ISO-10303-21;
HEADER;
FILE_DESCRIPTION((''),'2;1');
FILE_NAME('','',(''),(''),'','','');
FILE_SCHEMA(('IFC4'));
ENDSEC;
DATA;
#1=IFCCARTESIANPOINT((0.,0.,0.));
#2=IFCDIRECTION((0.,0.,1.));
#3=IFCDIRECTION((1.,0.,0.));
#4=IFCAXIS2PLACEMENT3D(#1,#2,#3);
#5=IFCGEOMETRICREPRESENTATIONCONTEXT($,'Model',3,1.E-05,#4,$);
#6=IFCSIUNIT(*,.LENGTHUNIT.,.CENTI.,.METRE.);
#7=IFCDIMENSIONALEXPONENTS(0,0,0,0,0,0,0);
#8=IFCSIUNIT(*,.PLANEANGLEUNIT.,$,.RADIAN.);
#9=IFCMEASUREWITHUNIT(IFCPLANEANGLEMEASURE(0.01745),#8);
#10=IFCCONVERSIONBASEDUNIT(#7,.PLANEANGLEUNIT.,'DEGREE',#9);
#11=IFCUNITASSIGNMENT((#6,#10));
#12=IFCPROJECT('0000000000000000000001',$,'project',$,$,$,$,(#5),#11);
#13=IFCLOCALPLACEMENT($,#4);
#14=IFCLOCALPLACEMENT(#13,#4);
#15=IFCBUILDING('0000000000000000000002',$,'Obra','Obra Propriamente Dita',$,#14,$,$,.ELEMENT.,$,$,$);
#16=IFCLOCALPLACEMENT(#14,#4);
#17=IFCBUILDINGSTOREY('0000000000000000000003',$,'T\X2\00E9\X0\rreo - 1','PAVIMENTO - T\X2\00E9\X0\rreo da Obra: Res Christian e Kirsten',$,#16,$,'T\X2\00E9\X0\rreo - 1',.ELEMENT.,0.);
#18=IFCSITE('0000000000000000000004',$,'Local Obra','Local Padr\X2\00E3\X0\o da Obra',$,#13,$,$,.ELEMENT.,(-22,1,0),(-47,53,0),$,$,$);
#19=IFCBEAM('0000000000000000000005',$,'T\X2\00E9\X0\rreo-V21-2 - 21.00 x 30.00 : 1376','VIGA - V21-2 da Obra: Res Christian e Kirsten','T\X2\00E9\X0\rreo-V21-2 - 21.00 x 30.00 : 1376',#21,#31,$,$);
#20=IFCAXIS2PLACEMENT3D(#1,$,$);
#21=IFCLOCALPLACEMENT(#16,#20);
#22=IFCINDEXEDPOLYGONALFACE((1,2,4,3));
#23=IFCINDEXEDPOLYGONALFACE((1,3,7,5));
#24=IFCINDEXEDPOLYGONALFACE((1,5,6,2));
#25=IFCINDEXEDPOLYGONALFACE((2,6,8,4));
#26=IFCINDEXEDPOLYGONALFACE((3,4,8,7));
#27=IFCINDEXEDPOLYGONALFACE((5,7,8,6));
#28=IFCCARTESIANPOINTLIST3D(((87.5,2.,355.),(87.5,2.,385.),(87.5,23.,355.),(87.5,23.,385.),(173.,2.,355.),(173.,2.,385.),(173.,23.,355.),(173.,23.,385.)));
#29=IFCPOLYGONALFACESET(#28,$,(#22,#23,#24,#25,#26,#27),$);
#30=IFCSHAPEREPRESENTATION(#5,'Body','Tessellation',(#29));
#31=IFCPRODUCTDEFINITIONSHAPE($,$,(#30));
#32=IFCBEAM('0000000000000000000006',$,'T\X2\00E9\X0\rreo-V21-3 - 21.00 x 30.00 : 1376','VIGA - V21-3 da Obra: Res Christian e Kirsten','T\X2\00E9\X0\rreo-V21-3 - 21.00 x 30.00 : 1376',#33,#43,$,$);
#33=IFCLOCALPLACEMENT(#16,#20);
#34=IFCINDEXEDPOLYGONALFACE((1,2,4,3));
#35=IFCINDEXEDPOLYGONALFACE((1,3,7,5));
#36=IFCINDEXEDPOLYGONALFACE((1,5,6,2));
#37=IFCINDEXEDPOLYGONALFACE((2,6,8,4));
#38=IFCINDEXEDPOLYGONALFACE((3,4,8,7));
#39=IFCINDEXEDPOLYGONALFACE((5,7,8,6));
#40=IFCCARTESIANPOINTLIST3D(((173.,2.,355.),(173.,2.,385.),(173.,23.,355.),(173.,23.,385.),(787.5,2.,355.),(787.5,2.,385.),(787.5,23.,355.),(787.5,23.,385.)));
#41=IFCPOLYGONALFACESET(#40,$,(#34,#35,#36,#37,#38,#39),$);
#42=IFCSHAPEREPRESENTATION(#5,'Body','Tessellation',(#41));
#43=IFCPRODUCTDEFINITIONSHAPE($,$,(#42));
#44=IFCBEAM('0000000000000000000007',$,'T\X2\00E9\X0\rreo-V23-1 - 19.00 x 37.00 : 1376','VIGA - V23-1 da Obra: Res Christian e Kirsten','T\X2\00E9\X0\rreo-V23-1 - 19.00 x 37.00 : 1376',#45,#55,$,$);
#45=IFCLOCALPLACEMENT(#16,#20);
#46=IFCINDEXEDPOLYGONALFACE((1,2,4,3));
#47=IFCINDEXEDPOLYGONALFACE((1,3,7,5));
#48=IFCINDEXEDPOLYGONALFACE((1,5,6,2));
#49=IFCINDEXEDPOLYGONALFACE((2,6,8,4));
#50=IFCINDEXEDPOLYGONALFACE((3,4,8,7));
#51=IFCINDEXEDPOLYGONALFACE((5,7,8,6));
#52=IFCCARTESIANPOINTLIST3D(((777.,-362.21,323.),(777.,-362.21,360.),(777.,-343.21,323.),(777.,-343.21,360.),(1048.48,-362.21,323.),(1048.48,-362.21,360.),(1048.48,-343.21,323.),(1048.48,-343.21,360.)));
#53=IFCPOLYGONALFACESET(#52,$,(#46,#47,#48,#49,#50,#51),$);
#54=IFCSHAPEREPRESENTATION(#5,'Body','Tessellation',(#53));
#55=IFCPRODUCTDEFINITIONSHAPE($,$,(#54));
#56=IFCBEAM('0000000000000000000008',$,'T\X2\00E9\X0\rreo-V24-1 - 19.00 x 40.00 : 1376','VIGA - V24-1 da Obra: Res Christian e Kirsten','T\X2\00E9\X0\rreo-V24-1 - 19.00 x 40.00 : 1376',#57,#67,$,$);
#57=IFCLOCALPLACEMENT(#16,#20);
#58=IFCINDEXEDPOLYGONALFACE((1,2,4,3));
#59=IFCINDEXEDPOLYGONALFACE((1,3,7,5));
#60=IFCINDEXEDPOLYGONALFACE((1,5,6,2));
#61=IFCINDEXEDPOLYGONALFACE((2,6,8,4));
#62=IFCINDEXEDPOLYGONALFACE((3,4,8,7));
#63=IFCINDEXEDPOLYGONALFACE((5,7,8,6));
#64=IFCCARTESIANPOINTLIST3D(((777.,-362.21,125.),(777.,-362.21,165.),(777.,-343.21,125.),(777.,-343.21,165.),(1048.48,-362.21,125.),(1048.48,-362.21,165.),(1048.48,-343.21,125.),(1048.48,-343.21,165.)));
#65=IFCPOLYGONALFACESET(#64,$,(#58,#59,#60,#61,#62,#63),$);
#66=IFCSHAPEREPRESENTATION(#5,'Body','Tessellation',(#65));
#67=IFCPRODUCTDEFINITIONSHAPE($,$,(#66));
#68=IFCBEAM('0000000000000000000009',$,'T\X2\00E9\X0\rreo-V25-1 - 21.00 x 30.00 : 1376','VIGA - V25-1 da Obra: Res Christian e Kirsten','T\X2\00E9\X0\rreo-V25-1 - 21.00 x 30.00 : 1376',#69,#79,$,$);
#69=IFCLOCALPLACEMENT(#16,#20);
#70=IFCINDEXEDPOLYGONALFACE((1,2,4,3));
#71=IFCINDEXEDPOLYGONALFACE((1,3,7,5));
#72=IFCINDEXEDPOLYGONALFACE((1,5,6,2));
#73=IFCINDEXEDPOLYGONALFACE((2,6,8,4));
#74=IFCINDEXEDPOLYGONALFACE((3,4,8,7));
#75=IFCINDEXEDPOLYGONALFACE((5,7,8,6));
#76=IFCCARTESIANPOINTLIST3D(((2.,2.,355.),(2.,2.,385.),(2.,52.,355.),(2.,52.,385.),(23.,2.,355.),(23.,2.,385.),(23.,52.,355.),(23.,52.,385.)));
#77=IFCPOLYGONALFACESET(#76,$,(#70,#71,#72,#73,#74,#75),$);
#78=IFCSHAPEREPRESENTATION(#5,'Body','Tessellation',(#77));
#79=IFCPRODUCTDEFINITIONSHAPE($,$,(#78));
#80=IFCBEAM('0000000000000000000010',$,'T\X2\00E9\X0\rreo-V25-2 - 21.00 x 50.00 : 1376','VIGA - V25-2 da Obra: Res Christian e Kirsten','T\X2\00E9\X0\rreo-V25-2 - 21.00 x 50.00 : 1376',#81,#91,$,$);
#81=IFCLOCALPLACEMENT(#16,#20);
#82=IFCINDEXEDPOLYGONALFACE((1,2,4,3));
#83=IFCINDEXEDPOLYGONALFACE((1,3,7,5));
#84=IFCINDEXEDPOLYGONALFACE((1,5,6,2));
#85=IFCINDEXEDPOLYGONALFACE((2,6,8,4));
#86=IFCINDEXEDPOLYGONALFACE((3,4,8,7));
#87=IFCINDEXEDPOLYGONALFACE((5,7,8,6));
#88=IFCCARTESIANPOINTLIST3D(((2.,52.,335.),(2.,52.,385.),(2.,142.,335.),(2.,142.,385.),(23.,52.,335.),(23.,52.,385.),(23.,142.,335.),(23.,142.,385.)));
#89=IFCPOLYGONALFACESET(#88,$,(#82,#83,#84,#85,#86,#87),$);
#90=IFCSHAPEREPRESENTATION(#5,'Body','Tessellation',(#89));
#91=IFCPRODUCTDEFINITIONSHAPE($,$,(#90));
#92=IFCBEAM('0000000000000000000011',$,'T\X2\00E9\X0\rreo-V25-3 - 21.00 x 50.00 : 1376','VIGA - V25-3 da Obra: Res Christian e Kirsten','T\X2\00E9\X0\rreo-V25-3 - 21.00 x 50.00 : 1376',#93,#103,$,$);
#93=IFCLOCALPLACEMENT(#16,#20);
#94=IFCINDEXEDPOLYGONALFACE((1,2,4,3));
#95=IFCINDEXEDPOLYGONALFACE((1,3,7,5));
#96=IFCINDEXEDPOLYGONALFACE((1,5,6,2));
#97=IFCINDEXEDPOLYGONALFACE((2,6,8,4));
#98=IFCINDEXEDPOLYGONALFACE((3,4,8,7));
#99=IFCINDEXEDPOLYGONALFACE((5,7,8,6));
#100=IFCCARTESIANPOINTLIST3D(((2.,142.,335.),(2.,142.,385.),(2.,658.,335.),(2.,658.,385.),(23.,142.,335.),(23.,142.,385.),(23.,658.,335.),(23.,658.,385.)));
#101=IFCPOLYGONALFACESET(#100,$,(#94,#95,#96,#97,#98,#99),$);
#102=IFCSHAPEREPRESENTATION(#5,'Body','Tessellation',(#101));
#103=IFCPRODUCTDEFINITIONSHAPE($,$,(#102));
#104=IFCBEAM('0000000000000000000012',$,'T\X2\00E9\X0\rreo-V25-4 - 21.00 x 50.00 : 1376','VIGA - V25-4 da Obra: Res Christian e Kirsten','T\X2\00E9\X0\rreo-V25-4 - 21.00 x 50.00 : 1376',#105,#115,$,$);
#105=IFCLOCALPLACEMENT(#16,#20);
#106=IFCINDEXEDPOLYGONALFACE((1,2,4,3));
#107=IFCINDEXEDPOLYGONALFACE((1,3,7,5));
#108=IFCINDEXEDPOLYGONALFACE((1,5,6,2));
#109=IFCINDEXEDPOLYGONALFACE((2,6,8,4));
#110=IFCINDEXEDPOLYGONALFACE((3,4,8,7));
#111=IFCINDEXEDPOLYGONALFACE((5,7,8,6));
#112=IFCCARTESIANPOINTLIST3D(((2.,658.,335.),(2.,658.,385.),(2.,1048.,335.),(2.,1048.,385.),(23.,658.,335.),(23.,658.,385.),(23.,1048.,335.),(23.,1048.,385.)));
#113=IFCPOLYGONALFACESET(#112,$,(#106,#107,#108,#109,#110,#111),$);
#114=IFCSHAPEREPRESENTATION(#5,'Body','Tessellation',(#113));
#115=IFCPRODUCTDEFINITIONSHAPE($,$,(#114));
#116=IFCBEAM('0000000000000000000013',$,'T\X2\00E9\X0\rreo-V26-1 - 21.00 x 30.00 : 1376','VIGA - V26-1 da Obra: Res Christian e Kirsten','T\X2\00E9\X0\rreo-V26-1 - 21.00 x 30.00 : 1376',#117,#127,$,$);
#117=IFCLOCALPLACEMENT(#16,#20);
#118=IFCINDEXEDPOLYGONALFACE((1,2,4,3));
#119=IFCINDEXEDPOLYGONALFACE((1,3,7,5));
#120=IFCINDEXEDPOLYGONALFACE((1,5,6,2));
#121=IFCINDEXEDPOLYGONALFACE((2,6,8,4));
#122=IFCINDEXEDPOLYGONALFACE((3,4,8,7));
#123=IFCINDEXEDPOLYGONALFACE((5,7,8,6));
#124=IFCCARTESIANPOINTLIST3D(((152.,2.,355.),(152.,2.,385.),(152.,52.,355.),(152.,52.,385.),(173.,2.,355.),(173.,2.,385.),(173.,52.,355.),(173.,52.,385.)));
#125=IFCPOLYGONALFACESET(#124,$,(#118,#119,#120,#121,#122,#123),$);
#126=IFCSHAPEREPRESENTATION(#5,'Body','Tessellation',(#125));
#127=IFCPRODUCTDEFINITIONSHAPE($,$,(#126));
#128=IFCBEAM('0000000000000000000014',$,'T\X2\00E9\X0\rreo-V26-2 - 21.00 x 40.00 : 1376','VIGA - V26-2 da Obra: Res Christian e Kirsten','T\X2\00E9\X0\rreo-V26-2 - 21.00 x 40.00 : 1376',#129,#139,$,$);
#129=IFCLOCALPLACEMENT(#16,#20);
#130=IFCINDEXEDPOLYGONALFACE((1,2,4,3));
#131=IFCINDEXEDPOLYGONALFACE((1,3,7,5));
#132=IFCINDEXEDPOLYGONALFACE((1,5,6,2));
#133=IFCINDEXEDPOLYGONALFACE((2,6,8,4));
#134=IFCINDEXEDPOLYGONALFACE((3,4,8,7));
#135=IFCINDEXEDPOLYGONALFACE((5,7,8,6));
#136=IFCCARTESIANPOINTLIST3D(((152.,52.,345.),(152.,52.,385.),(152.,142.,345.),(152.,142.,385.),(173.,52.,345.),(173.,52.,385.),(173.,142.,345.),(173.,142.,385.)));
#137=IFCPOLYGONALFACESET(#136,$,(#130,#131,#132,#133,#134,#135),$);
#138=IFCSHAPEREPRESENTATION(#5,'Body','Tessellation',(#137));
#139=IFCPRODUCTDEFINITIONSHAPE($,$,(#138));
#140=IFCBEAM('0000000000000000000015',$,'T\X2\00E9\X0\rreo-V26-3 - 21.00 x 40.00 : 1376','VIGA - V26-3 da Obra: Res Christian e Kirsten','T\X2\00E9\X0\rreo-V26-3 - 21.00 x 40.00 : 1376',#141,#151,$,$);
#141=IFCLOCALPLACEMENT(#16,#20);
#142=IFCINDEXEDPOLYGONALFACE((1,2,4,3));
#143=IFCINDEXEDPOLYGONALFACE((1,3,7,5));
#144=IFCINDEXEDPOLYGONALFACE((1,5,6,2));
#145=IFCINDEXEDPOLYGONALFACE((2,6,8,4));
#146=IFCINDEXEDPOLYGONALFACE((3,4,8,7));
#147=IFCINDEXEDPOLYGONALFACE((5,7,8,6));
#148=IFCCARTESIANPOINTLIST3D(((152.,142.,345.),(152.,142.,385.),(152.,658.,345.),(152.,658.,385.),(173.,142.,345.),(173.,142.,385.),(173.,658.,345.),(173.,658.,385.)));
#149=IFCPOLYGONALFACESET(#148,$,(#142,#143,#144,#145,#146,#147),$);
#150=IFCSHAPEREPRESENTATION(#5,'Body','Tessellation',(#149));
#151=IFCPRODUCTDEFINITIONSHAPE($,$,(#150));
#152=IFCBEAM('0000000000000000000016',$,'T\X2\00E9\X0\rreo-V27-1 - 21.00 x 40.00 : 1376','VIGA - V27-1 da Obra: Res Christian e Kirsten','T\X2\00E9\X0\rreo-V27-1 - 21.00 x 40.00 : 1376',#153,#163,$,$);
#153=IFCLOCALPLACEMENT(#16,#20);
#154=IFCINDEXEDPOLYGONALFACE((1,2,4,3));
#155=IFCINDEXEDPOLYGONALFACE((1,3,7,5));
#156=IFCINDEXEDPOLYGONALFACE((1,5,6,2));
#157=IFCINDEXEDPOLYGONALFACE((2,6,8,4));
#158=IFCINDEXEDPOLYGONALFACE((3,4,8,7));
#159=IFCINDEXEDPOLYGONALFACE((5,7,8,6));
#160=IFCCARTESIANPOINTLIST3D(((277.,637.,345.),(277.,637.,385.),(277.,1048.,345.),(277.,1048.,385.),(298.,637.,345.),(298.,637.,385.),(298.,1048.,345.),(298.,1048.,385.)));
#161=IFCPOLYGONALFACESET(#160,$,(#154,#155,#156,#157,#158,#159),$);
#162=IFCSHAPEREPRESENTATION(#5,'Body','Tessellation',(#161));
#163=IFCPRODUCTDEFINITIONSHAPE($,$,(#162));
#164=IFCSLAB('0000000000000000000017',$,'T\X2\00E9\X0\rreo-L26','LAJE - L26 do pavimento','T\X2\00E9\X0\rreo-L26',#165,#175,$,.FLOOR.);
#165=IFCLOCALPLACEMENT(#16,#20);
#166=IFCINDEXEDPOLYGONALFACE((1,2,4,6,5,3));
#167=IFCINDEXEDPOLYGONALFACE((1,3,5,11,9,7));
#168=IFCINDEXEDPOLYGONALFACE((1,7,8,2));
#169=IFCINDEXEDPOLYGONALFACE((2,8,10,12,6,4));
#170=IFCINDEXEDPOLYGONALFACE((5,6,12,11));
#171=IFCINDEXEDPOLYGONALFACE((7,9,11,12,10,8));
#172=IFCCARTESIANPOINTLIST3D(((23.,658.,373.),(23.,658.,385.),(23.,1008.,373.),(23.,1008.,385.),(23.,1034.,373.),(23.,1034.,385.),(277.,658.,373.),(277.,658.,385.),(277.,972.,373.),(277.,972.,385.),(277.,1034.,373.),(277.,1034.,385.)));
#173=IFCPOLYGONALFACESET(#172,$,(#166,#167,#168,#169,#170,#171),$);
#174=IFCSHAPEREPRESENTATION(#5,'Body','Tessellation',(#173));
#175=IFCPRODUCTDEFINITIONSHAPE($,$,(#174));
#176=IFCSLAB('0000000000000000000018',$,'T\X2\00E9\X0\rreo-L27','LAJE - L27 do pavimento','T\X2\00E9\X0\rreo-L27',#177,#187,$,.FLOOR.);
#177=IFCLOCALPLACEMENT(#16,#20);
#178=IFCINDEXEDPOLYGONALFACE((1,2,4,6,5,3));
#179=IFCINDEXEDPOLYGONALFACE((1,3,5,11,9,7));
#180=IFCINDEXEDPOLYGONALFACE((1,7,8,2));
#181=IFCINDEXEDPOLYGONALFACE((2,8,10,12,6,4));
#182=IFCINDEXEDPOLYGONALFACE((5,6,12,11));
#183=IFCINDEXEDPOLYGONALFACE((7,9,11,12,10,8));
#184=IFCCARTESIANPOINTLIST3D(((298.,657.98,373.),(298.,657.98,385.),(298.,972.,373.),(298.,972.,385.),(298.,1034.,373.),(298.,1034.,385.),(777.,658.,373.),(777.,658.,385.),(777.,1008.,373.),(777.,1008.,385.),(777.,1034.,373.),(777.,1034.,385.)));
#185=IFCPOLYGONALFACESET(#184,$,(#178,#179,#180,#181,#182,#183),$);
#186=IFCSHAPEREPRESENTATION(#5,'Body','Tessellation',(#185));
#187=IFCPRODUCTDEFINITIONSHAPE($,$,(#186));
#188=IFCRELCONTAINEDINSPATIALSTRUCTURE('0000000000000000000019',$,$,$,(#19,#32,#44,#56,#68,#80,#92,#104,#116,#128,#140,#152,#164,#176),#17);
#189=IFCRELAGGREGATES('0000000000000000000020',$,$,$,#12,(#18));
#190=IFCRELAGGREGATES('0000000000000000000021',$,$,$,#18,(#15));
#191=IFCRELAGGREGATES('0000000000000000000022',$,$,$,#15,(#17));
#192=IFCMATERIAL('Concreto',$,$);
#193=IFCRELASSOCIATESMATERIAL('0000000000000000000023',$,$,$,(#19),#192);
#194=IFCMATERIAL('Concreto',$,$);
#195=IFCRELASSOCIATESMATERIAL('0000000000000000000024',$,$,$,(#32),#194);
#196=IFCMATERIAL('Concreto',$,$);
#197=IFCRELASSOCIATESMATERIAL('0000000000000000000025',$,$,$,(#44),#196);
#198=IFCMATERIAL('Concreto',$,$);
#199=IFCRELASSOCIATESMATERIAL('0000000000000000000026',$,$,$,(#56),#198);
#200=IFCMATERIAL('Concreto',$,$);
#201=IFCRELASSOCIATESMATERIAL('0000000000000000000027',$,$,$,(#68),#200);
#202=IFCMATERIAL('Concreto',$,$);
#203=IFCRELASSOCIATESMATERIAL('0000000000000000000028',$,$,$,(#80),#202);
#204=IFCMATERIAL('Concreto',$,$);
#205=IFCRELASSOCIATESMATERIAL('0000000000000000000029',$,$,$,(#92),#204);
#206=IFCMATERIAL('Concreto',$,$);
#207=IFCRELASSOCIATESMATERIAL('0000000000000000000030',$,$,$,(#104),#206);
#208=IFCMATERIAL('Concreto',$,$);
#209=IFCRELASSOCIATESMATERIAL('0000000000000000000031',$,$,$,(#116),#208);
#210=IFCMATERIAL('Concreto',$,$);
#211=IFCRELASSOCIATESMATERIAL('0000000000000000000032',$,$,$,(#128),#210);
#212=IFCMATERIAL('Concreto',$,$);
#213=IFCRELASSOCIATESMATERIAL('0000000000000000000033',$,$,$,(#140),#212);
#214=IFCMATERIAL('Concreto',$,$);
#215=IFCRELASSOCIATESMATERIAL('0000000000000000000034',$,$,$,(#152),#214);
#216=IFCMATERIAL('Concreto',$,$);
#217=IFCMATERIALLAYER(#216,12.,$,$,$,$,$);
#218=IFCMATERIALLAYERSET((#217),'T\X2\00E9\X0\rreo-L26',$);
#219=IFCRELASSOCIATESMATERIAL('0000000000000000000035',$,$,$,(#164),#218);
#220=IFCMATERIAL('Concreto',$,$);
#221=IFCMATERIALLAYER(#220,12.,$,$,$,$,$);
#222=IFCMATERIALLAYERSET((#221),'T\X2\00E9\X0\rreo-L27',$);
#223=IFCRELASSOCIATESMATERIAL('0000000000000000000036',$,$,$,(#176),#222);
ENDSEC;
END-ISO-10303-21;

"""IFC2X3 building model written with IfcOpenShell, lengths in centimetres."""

from ifc_helpers import new_model, entity, si_unit, converted_unit, frame, origin_with_axes, place, context, project, spatial, polyline, outline, extrude, material, layer, layer_set, layer_usage, element, save


model = new_model("IFC2X3")

# Units and contexts
model_context = context("Model", 3, precision=1e-05, world=origin_with_axes())
ifc_project = project(units=[si_unit("LENGTHUNIT", "METRE", prefix="CENTI"), converted_unit("PLANEANGLEUNIT", "DEGREE", entity("IfcPlaneAngleMeasure", 0.01745), si_unit("PLANEANGLEUNIT", "RADIAN"), dimensions=[0, 0, 0, 0, 0, 0, 0])], contexts=[model_context])

# Site, building, storey
site_placement = place(None, origin_with_axes())
site = spatial("IfcSite", under=ifc_project, at=site_placement, Name="Local Obra", Description="Local Padrão da Obra", CompositionType="ELEMENT", RefLatitude=(-22, 1, 0), RefLongitude=(-47, 53, 0))
building_placement = place(site_placement, origin_with_axes())
building = spatial("IfcBuilding", under=site, at=building_placement, Name="Obra", Description="Obra Propriamente Dita", CompositionType="ELEMENT")
storey_placement = place(building_placement, origin_with_axes())
storey = spatial("IfcBuildingStorey", under=building, at=storey_placement, Name="Térreo - 1", Description="PAVIMENTO - Térreo da Obra: Res Christian e Kirsten", LongName="Térreo - 1", CompositionType="ELEMENT", Elevation=0.0)

# Beams
ifc_material_1 = material(Name="Concreto")
beam_1_placement = place(storey_placement, frame((87.5, 2.0, 385.0), z_axis=(1.0, 0.0, 0.0), x_axis=(0.0, -1.0, 0.0)))
element("IfcBeam", 1, at=beam_1_placement, inside=storey, material=ifc_material_1, Name="Térreo-V21-2 - 21.00 x 30.00 : 1376", Description="VIGA - V21-2 da Obra: Res Christian e Kirsten", ObjectType="Térreo-V21-2 - 21.00 x 30.00 : 1376", context=model_context, shape_type="SweptSolid", body=[
    extrude(outline(polyline([(-21.0, 0.0), (0.0, 0.0), (0.0, 30.0), (-21.0, 30.0), (-21.0, 0.0)])), origin_with_axes(), (0.0, 0.0, 1.0), 85.5),
])
ifc_material_2 = material(Name="Concreto")
beam_2_placement = place(storey_placement, frame((173.0, 2.0, 385.0), z_axis=(1.0, 0.0, 0.0), x_axis=(0.0, -1.0, 0.0)))
element("IfcBeam", 2, at=beam_2_placement, inside=storey, material=ifc_material_2, Name="Térreo-V21-3 - 21.00 x 30.00 : 1376", Description="VIGA - V21-3 da Obra: Res Christian e Kirsten", ObjectType="Térreo-V21-3 - 21.00 x 30.00 : 1376", context=model_context, shape_type="SweptSolid", body=[
    extrude(outline(polyline([(-21.0, 0.0), (0.0, 0.0), (0.0, 30.0), (-21.0, 30.0), (-21.0, 0.0)])), origin_with_axes(), (0.0, 0.0, 1.0), 614.5),
])
ifc_material_3 = material(Name="Concreto")
beam_3_placement = place(storey_placement, frame((777.0, -362.21, 360.0), z_axis=(1.0, 0.0, 0.0), x_axis=(0.0, -1.0, 0.0)))
element("IfcBeam", 3, at=beam_3_placement, inside=storey, material=ifc_material_3, Name="Térreo-V23-1 - 19.00 x 37.00 : 1376", Description="VIGA - V23-1 da Obra: Res Christian e Kirsten", ObjectType="Térreo-V23-1 - 19.00 x 37.00 : 1376", context=model_context, shape_type="SweptSolid", body=[
    extrude(outline(polyline([(-19.0, 0.0), (0.0, 0.0), (0.0, 37.0), (-19.0, 37.0), (-19.0, 0.0)])), origin_with_axes(), (0.0, 0.0, 1.0), 271.48),
])
ifc_material_4 = material(Name="Concreto")
beam_4_placement = place(storey_placement, frame((777.0, -362.21, 165.0), z_axis=(1.0, 0.0, 0.0), x_axis=(0.0, -1.0, 0.0)))
element("IfcBeam", 4, at=beam_4_placement, inside=storey, material=ifc_material_4, Name="Térreo-V24-1 - 19.00 x 40.00 : 1376", Description="VIGA - V24-1 da Obra: Res Christian e Kirsten", ObjectType="Térreo-V24-1 - 19.00 x 40.00 : 1376", context=model_context, shape_type="SweptSolid", body=[
    extrude(outline(polyline([(-19.0, 0.0), (0.0, 0.0), (0.0, 40.0), (-19.0, 40.0), (-19.0, 0.0)])), origin_with_axes(), (0.0, 0.0, 1.0), 271.48),
])
ifc_material_5 = material(Name="Concreto")
beam_5_placement = place(storey_placement, frame((2.0, 2.0, 385.0), z_axis=(0.0, 1.0, 0.0), x_axis=(1.0, 0.0, 0.0)))
element("IfcBeam", 5, at=beam_5_placement, inside=storey, material=ifc_material_5, Name="Térreo-V25-1 - 21.00 x 30.00 : 1376", Description="VIGA - V25-1 da Obra: Res Christian e Kirsten", ObjectType="Térreo-V25-1 - 21.00 x 30.00 : 1376", context=model_context, shape_type="SweptSolid", body=[
    extrude(outline(polyline([(0.0, 0.0), (21.0, 0.0), (21.0, 30.0), (0.0, 30.0), (0.0, 0.0)])), origin_with_axes(), (0.0, 0.0, 1.0), 50.0),
])
ifc_material_6 = material(Name="Concreto")
beam_6_placement = place(storey_placement, frame((2.0, 52.0, 385.0), z_axis=(0.0, 1.0, 0.0), x_axis=(1.0, 0.0, 0.0)))
element("IfcBeam", 6, at=beam_6_placement, inside=storey, material=ifc_material_6, Name="Térreo-V25-2 - 21.00 x 50.00 : 1376", Description="VIGA - V25-2 da Obra: Res Christian e Kirsten", ObjectType="Térreo-V25-2 - 21.00 x 50.00 : 1376", context=model_context, shape_type="SweptSolid", body=[
    extrude(outline(polyline([(0.0, 0.0), (21.0, 0.0), (21.0, 50.0), (0.0, 50.0), (0.0, 0.0)])), origin_with_axes(), (0.0, 0.0, 1.0), 90.0),
])
ifc_material_7 = material(Name="Concreto")
beam_7_placement = place(storey_placement, frame((2.0, 142.0, 385.0), z_axis=(0.0, 1.0, 0.0), x_axis=(1.0, 0.0, 0.0)))
element("IfcBeam", 7, at=beam_7_placement, inside=storey, material=ifc_material_7, Name="Térreo-V25-3 - 21.00 x 50.00 : 1376", Description="VIGA - V25-3 da Obra: Res Christian e Kirsten", ObjectType="Térreo-V25-3 - 21.00 x 50.00 : 1376", context=model_context, shape_type="SweptSolid", body=[
    extrude(outline(polyline([(0.0, 0.0), (21.0, 0.0), (21.0, 50.0), (0.0, 50.0), (0.0, 0.0)])), origin_with_axes(), (0.0, 0.0, 1.0), 516.0),
])
ifc_material_8 = material(Name="Concreto")
beam_8_placement = place(storey_placement, frame((2.0, 658.0, 385.0), z_axis=(0.0, 1.0, 0.0), x_axis=(1.0, 0.0, 0.0)))
element("IfcBeam", 8, at=beam_8_placement, inside=storey, material=ifc_material_8, Name="Térreo-V25-4 - 21.00 x 50.00 : 1376", Description="VIGA - V25-4 da Obra: Res Christian e Kirsten", ObjectType="Térreo-V25-4 - 21.00 x 50.00 : 1376", context=model_context, shape_type="SweptSolid", body=[
    extrude(outline(polyline([(0.0, 0.0), (21.0, 0.0), (21.0, 50.0), (0.0, 50.0), (0.0, 0.0)])), origin_with_axes(), (0.0, 0.0, 1.0), 390.0),
])
ifc_material_9 = material(Name="Concreto")
beam_9_placement = place(storey_placement, frame((173.0, 2.0, 385.0), z_axis=(0.0, 1.0, 0.0), x_axis=(1.0, 0.0, 0.0)))
element("IfcBeam", 9, at=beam_9_placement, inside=storey, material=ifc_material_9, Name="Térreo-V26-1 - 21.00 x 30.00 : 1376", Description="VIGA - V26-1 da Obra: Res Christian e Kirsten", ObjectType="Térreo-V26-1 - 21.00 x 30.00 : 1376", context=model_context, shape_type="SweptSolid", body=[
    extrude(outline(polyline([(-21.0, 0.0), (0.0, 0.0), (0.0, 30.0), (-21.0, 30.0), (-21.0, 0.0)])), origin_with_axes(), (0.0, 0.0, 1.0), 50.0),
])
ifc_material_10 = material(Name="Concreto")
beam_10_placement = place(storey_placement, frame((173.0, 52.0, 385.0), z_axis=(0.0, 1.0, 0.0), x_axis=(1.0, 0.0, 0.0)))
element("IfcBeam", 10, at=beam_10_placement, inside=storey, material=ifc_material_10, Name="Térreo-V26-2 - 21.00 x 40.00 : 1376", Description="VIGA - V26-2 da Obra: Res Christian e Kirsten", ObjectType="Térreo-V26-2 - 21.00 x 40.00 : 1376", context=model_context, shape_type="SweptSolid", body=[
    extrude(outline(polyline([(-21.0, 0.0), (0.0, 0.0), (0.0, 40.0), (-21.0, 40.0), (-21.0, 0.0)])), origin_with_axes(), (0.0, 0.0, 1.0), 90.0),
])
ifc_material_11 = material(Name="Concreto")
beam_11_placement = place(storey_placement, frame((173.0, 142.0, 385.0), z_axis=(0.0, 1.0, 0.0), x_axis=(1.0, 0.0, 0.0)))
element("IfcBeam", 11, at=beam_11_placement, inside=storey, material=ifc_material_11, Name="Térreo-V26-3 - 21.00 x 40.00 : 1376", Description="VIGA - V26-3 da Obra: Res Christian e Kirsten", ObjectType="Térreo-V26-3 - 21.00 x 40.00 : 1376", context=model_context, shape_type="SweptSolid", body=[
    extrude(outline(polyline([(-21.0, 0.0), (0.0, 0.0), (0.0, 40.0), (-21.0, 40.0), (-21.0, 0.0)])), origin_with_axes(), (0.0, 0.0, 1.0), 516.0),
])
ifc_material_12 = material(Name="Concreto")
beam_12_placement = place(storey_placement, frame((277.0, 637.0, 385.0), z_axis=(0.0, 1.0, 0.0), x_axis=(1.0, 0.0, 0.0)))
element("IfcBeam", 12, at=beam_12_placement, inside=storey, material=ifc_material_12, Name="Térreo-V27-1 - 21.00 x 40.00 : 1376", Description="VIGA - V27-1 da Obra: Res Christian e Kirsten", ObjectType="Térreo-V27-1 - 21.00 x 40.00 : 1376", context=model_context, shape_type="SweptSolid", body=[
    extrude(outline(polyline([(0.0, 0.0), (21.0, 0.0), (21.0, 40.0), (0.0, 40.0), (0.0, 0.0)])), origin_with_axes(), (0.0, 0.0, 1.0), 411.0),
])

# Slabs
ifc_material_13 = material(Name="Concreto")
ifc_layer_1 = layer(ifc_material_13, 12.0)
ifc_layer_set_1 = layer_set([ifc_layer_1], Name="Térreo-L26")
ifc_layer_usage_1 = layer_usage(ifc_layer_set_1, "AXIS3", "POSITIVE", 0.0)
slab_1_placement = place(storey_placement, frame((277.0, 972.0, 373.0), z_axis=(0.0, 0.0, 1.0), x_axis=(1.0, 0.0, 0.0)))
element("IfcSlab", 13, at=slab_1_placement, inside=storey, material=ifc_layer_usage_1, Name="Térreo-L26", Description="LAJE - L26 do pavimento", ObjectType="Térreo-L26", PredefinedType="FLOOR", context=model_context, shape_type="SweptSolid", body=[
    extrude(outline(polyline([(0.0, 62.0), (-254.0, 62.0), (-254.0, 36.0), (-254.0, -314.0), (0.0, -314.0), (0.0, 0.0), (0.0, 62.0)])), origin_with_axes(), (0.0, 0.0, 1.0), 12.0),
])
ifc_material_14 = material(Name="Concreto")
ifc_layer_2 = layer(ifc_material_14, 12.0)
ifc_layer_set_2 = layer_set([ifc_layer_2], Name="Térreo-L27")
ifc_layer_usage_2 = layer_usage(ifc_layer_set_2, "AXIS3", "POSITIVE", 0.0)
slab_2_placement = place(storey_placement, frame((777.0, 1008.0, 373.0), z_axis=(0.0, 0.0, 1.0), x_axis=(1.0, 0.0, 0.0)))
element("IfcSlab", 14, at=slab_2_placement, inside=storey, material=ifc_layer_usage_2, Name="Térreo-L27", Description="LAJE - L27 do pavimento", ObjectType="Térreo-L27", PredefinedType="FLOOR", context=model_context, shape_type="SweptSolid", body=[
    extrude(outline(polyline([(0.0, 26.0), (-479.0, 26.0), (-479.0, -36.0), (-479.0, -350.02), (0.0, -350.0), (0.0, 0.0), (0.0, 26.0)])), origin_with_axes(), (0.0, 0.0, 1.0), 12.0),
])

save(model, "model.ifc")
